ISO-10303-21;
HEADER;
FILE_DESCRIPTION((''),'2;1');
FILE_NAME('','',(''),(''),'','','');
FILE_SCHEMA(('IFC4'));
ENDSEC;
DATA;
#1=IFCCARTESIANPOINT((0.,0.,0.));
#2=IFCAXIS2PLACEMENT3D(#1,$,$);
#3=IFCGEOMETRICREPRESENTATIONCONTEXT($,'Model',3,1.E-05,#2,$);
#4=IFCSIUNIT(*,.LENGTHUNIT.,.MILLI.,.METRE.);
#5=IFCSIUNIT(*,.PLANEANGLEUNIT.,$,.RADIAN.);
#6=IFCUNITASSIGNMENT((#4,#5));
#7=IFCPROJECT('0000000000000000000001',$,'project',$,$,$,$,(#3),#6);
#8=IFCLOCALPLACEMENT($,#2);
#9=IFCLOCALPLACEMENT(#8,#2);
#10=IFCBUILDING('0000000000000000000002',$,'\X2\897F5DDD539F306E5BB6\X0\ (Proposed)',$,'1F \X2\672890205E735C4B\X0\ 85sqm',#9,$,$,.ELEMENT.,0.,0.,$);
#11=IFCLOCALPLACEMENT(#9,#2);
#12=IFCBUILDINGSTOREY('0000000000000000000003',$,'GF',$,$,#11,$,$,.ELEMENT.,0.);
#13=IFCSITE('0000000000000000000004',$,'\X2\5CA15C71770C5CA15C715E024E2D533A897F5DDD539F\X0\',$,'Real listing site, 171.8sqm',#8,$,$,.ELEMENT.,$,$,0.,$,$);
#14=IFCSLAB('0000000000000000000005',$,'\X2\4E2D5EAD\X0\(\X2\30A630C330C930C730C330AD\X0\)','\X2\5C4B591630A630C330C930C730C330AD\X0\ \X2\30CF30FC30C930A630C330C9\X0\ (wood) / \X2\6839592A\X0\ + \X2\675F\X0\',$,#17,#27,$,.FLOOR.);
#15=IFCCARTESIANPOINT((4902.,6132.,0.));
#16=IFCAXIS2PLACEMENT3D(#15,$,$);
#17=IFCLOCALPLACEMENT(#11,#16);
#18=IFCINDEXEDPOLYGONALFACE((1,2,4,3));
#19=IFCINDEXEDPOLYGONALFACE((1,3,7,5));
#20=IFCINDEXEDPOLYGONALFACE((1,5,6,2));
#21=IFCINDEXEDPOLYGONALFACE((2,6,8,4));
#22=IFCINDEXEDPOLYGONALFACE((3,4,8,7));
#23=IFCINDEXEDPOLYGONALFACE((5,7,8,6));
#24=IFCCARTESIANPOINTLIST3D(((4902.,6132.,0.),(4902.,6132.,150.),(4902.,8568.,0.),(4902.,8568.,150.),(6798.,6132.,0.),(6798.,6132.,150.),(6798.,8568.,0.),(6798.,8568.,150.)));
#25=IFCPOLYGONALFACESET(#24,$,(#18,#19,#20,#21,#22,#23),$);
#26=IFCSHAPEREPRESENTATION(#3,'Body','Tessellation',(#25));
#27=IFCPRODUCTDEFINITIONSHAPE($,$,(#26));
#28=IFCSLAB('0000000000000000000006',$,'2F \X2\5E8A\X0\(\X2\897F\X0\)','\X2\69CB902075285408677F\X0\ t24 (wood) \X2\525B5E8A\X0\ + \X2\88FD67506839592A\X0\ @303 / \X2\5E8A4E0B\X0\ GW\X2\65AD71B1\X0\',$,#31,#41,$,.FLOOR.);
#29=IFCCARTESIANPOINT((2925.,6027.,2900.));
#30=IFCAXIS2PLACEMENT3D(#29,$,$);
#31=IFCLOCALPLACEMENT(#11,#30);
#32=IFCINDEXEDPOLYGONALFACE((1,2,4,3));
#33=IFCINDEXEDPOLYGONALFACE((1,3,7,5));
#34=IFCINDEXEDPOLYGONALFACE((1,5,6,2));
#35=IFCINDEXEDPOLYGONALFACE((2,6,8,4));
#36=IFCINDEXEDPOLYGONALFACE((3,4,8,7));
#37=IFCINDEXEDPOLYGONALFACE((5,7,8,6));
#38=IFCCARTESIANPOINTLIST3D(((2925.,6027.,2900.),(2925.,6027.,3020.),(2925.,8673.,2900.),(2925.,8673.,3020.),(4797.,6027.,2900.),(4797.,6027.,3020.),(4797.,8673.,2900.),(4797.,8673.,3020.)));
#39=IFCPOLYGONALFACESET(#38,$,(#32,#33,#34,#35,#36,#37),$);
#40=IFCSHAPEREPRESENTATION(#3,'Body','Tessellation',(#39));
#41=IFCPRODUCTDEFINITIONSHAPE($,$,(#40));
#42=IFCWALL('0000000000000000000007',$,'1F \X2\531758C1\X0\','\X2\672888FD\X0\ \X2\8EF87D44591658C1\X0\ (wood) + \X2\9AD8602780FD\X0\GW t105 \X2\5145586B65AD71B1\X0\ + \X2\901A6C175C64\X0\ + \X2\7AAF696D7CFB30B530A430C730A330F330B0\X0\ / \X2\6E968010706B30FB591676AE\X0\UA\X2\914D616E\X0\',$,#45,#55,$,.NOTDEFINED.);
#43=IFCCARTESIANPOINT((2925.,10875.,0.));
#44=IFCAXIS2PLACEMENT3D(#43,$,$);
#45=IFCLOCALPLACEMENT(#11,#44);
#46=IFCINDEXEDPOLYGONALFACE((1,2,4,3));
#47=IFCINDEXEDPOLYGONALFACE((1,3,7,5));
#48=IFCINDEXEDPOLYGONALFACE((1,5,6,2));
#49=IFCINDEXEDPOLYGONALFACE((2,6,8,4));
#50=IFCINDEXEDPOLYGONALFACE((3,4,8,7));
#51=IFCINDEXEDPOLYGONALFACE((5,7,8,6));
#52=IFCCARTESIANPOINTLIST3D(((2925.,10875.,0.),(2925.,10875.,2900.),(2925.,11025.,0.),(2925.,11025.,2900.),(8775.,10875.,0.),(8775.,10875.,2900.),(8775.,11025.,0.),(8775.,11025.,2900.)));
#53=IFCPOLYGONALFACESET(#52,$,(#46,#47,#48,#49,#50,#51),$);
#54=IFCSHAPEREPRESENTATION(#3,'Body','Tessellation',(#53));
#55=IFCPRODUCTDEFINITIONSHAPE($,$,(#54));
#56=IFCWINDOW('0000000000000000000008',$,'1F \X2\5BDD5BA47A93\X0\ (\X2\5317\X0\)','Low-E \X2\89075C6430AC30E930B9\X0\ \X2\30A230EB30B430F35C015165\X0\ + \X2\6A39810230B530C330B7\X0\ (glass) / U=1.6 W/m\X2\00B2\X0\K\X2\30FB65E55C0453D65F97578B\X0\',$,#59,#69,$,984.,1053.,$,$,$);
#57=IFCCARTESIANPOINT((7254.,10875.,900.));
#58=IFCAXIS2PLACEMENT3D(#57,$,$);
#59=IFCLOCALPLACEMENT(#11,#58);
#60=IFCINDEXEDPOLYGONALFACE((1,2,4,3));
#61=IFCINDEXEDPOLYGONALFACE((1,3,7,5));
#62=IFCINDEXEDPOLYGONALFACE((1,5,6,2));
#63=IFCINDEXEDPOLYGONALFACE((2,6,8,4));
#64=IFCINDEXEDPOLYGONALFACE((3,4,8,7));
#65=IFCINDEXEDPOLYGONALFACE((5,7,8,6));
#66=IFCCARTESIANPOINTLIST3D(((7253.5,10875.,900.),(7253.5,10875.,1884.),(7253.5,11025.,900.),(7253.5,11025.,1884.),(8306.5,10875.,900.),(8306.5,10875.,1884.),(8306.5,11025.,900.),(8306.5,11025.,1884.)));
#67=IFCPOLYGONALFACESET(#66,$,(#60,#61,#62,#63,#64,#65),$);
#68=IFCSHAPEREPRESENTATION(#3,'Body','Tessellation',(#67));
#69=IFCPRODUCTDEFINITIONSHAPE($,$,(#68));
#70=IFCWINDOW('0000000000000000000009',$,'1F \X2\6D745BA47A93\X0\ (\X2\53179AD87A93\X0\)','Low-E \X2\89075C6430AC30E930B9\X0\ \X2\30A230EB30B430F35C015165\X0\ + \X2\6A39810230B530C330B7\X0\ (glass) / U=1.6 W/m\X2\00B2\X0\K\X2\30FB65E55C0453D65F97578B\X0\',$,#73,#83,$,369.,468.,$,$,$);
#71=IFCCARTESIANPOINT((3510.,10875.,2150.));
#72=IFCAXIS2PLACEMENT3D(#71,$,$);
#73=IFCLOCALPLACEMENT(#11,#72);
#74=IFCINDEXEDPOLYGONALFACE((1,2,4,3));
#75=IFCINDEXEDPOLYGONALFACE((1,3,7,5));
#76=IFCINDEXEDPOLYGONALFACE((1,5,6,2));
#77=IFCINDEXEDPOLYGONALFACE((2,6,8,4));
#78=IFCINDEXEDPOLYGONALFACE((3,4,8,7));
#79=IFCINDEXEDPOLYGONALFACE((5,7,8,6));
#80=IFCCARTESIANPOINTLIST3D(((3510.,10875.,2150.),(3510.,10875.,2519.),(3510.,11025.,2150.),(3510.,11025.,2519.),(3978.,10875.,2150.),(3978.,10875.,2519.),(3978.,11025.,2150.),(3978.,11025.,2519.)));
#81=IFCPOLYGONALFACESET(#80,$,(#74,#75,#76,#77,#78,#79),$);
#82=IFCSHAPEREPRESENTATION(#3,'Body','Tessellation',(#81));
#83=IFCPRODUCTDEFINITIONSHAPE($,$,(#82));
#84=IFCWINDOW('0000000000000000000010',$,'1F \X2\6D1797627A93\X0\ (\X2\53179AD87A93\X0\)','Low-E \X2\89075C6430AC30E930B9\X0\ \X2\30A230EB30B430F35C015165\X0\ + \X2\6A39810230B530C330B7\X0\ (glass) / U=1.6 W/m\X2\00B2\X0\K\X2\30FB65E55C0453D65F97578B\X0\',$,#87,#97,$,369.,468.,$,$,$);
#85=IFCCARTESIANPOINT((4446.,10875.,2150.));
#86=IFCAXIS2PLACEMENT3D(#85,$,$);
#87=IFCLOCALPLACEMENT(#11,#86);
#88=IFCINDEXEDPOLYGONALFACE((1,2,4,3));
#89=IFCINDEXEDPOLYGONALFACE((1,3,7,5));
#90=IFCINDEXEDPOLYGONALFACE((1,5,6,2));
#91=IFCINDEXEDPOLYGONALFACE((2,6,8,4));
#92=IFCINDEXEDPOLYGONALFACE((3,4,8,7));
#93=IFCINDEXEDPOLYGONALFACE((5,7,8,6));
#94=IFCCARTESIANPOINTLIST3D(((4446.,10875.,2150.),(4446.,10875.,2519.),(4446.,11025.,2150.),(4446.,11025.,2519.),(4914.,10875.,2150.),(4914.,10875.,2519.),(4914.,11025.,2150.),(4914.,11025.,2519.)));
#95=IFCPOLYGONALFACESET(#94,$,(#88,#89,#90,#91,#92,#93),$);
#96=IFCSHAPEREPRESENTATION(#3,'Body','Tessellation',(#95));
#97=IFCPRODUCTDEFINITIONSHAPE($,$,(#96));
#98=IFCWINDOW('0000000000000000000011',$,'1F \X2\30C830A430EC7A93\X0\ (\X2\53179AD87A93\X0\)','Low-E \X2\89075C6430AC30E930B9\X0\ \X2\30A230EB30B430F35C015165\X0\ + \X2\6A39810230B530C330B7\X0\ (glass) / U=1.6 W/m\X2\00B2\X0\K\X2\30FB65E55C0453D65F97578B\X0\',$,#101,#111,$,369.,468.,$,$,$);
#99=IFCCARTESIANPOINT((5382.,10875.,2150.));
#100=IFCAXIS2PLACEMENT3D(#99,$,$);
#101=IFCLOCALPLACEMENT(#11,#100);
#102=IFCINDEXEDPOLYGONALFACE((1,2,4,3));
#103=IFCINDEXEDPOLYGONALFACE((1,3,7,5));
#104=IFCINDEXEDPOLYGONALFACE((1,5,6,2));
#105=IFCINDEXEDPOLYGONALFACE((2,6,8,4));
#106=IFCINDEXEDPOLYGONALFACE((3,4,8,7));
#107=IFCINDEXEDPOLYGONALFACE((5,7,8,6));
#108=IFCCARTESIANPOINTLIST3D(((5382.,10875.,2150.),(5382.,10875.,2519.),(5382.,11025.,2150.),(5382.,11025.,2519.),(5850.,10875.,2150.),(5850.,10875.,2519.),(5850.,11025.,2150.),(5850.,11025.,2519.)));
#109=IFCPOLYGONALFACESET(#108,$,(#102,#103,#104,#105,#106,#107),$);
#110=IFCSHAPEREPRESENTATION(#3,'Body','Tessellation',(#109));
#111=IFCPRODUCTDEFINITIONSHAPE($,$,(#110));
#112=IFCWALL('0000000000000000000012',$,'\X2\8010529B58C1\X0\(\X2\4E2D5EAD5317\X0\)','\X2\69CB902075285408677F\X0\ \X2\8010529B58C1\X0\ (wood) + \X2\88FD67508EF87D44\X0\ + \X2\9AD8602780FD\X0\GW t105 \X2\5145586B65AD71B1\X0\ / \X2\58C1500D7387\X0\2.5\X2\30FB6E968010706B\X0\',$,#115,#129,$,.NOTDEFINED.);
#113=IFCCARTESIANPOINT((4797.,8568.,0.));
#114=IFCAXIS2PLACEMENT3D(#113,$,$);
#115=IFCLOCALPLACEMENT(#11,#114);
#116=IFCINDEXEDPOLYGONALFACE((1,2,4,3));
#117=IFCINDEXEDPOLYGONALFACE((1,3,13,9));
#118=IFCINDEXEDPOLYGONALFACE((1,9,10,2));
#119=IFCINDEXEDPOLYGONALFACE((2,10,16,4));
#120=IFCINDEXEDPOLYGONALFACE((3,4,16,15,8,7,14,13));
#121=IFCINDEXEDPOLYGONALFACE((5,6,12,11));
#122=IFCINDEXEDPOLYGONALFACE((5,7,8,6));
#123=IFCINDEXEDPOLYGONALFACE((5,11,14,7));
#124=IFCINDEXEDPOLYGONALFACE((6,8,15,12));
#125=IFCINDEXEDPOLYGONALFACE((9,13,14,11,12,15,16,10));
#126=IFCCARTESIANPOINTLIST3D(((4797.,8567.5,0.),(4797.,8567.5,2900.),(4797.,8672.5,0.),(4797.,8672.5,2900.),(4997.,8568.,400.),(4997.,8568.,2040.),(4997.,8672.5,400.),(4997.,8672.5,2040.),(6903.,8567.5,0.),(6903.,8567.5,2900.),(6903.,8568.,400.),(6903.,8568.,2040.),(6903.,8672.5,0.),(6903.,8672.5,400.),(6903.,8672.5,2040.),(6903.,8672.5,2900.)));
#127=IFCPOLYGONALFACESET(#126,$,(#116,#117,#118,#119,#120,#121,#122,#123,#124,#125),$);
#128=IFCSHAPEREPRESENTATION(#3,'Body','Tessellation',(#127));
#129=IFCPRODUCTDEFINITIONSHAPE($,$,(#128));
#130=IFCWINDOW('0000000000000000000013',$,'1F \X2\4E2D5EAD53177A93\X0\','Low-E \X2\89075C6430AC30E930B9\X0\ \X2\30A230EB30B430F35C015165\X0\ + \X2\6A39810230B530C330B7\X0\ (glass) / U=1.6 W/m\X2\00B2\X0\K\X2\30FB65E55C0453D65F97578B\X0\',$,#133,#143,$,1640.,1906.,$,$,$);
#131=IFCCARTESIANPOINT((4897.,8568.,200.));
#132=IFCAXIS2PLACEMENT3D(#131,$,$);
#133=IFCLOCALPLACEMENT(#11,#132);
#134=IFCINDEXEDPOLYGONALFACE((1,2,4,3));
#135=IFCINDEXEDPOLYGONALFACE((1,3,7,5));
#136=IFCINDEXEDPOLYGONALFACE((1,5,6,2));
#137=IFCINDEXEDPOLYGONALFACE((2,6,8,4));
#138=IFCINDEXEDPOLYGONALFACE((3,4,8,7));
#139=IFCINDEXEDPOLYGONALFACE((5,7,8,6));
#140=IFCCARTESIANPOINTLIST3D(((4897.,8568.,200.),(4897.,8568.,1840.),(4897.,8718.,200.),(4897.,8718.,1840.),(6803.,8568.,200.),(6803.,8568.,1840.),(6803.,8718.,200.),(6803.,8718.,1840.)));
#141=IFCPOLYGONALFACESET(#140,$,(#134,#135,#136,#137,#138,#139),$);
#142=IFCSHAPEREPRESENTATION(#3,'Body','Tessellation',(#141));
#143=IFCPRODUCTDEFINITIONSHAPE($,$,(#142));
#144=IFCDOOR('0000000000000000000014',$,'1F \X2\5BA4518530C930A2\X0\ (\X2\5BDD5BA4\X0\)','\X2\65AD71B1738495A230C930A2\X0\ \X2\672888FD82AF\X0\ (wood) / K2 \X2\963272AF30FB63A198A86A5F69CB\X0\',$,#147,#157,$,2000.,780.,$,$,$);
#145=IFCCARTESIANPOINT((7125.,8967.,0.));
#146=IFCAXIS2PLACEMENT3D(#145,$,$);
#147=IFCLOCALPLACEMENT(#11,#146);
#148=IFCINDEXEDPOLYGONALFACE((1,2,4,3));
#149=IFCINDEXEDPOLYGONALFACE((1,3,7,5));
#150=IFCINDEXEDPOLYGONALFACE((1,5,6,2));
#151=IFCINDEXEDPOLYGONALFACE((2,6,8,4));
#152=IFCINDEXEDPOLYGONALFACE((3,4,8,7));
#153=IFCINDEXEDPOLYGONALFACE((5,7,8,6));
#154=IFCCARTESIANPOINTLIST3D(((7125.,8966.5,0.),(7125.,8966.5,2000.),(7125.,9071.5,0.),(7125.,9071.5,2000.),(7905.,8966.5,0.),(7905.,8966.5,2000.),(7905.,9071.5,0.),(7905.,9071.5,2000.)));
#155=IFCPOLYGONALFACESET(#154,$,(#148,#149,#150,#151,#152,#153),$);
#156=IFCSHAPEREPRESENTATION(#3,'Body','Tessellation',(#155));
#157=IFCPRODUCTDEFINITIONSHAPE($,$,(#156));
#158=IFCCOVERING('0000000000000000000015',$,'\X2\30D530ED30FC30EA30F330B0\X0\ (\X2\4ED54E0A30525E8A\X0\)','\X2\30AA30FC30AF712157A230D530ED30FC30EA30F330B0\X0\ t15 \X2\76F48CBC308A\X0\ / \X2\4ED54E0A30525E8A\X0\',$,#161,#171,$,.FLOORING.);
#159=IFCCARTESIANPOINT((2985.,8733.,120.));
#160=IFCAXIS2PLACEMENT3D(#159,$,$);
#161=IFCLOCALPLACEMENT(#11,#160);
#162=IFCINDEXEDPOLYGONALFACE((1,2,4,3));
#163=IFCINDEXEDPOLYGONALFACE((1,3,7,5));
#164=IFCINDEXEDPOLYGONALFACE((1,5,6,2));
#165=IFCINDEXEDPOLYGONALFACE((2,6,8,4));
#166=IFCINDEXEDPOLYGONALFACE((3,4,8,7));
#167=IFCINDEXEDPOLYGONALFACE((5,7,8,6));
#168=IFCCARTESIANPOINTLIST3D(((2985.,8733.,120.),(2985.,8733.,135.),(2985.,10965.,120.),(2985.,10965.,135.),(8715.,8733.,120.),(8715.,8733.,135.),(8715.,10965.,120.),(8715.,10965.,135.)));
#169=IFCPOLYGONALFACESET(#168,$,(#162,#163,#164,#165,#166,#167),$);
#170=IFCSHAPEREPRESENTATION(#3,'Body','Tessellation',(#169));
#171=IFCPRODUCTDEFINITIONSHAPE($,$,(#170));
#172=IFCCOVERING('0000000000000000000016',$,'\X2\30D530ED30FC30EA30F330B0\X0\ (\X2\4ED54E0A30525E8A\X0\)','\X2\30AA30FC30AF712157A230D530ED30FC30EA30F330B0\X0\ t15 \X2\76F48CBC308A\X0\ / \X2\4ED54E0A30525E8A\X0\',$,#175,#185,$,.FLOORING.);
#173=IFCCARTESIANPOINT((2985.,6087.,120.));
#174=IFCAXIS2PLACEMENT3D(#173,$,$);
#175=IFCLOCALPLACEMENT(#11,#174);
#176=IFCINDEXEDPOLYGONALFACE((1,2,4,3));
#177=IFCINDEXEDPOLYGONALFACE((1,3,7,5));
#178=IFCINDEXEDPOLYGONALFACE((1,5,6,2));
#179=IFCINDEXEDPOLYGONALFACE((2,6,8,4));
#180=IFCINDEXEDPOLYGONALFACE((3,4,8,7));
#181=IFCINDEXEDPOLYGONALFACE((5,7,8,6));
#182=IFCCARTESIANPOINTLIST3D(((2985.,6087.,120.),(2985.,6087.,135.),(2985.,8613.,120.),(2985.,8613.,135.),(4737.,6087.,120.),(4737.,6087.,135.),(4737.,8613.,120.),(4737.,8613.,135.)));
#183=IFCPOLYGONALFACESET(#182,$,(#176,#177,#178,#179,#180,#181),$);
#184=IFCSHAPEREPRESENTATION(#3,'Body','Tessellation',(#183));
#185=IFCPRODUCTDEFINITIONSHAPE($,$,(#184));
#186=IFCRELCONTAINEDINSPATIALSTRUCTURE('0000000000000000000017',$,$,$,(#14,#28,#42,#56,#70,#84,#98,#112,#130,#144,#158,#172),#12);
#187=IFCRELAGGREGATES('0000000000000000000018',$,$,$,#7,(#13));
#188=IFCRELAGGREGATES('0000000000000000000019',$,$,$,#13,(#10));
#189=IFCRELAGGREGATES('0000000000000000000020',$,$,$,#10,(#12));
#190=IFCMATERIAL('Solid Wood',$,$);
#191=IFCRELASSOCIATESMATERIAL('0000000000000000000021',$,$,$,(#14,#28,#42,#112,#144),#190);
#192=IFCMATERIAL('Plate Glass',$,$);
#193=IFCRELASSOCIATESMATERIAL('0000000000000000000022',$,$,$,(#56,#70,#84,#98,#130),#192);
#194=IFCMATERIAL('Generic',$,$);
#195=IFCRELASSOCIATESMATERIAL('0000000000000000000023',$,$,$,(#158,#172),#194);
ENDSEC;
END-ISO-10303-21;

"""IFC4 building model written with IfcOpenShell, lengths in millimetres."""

from ifc_helpers import new_model, si_unit, frame, frame_2d, origin, place, context, project, spatial, rectangle, extrude, material, element, fill, save


model = new_model("IFC4")

# Units and contexts
model_context = context("Model", 3, precision=1e-05, world=origin())
ifc_project = project(units=[si_unit("LENGTHUNIT", "METRE", prefix="MILLI"), si_unit("PLANEANGLEUNIT", "RADIAN")], contexts=[model_context])

# Site, building, storey
site_placement = place(None, origin())
site = spatial("IfcSite", under=ifc_project, at=site_placement, Name="岡山県岡山市中区西川原", ObjectType="Real listing site, 171.8sqm", CompositionType="ELEMENT", RefElevation=0.0)
building_placement = place(site_placement, origin())
building = spatial("IfcBuilding", under=site, at=building_placement, Name="西川原の家 (Proposed)", ObjectType="1F 木造平屋 85sqm", CompositionType="ELEMENT", ElevationOfRefHeight=0.0, ElevationOfTerrain=0.0)
storey_placement = place(building_placement, origin())
storey = spatial("IfcBuildingStorey", under=building, at=storey_placement, Name="GF", CompositionType="ELEMENT", Elevation=0.0)

# Slabs
ifc_material_1 = material(Name="Solid Wood")
slab_1_placement = place(storey_placement, frame((4902.0, 6132.0, 0.0)))
element("IfcSlab", 1, at=slab_1_placement, inside=storey, material=ifc_material_1, Name="中庭(ウッドデッキ)", Description="屋外ウッドデッキ ハードウッド (wood) / 根太 + 束", PredefinedType="FLOOR", context=model_context, shape_type="SweptSolid", body=[
    extrude(rectangle(XDim=1896.0, YDim=2436.0, at=frame_2d((948.0, 1218.0))), frame((4902.0, 6132.0, 0.0)), (0.0, 0.0, 1.0), 150.0),
])
slab_2_placement = place(storey_placement, frame((2925.0, 6027.0, 2900.0)))
element("IfcSlab", 2, at=slab_2_placement, inside=storey, material=ifc_material_1, Name="2F 床(西)", Description="構造用合板 t24 (wood) 剛床 + 製材根太 @303 / 床下 GW断熱", PredefinedType="FLOOR", context=model_context, shape_type="SweptSolid", body=[
    extrude(rectangle(XDim=1872.0, YDim=2646.0, at=frame_2d((936.0, 1323.0))), frame((2925.0, 6027.0, 2900.0)), (0.0, 0.0, 1.0), 120.0),
])

# Wall, openings, windows
wall_1_placement = place(storey_placement, frame((2925.0, 10875.0, 0.0)))
wall_1 = element("IfcWall", 3, at=wall_1_placement, inside=storey, material=ifc_material_1, Name="1F 北壁", Description="木製 軸組外壁 (wood) + 高性能GW t105 充填断熱 + 通気層 + 窯業系サイディング / 準耐火・外皮UA配慮", PredefinedType="NOTDEFINED", context=model_context, shape_type="SweptSolid", body=[
    extrude(rectangle(XDim=5850.0, YDim=150.0, at=frame_2d((2925.0, 75.0))), frame((2925.0, 10875.0, 0.0)), (0.0, 0.0, 1.0), 2900.0),
])
opening_1_placement = place(storey_placement, frame((7254.0, 10875.0, 900.0)))
opening_1 = element("IfcOpeningElement", 4, at=opening_1_placement, cuts=wall_1, PredefinedType="NOTDEFINED", context=model_context, shape_type="SweptSolid", body=[
    extrude(rectangle(XDim=1053.0, YDim=150.0, at=frame_2d((526.0, 75.0))), frame((7254.0, 10875.0, 900.0)), (0.0, 0.0, 1.0), 984.0),
])
opening_2_placement = place(storey_placement, frame((3510.0, 10875.0, 2150.0)))
opening_2 = element("IfcOpeningElement", 5, at=opening_2_placement, cuts=wall_1, PredefinedType="NOTDEFINED", context=model_context, shape_type="SweptSolid", body=[
    extrude(rectangle(XDim=468.0, YDim=150.0, at=frame_2d((234.0, 75.0))), frame((3510.0, 10875.0, 2150.0)), (0.0, 0.0, 1.0), 369.0),
])
opening_3_placement = place(storey_placement, frame((4446.0, 10875.0, 2150.0)))
opening_3 = element("IfcOpeningElement", 6, at=opening_3_placement, cuts=wall_1, PredefinedType="NOTDEFINED", context=model_context, shape_type="SweptSolid", body=[
    extrude(rectangle(XDim=468.0, YDim=150.0, at=frame_2d((234.0, 75.0))), frame((4446.0, 10875.0, 2150.0)), (0.0, 0.0, 1.0), 369.0),
])
opening_4_placement = place(storey_placement, frame((5382.0, 10875.0, 2150.0)))
opening_4 = element("IfcOpeningElement", 7, at=opening_4_placement, cuts=wall_1, PredefinedType="NOTDEFINED", context=model_context, shape_type="SweptSolid", body=[
    extrude(rectangle(XDim=468.0, YDim=150.0, at=frame_2d((234.0, 75.0))), frame((5382.0, 10875.0, 2150.0)), (0.0, 0.0, 1.0), 369.0),
])
ifc_material_2 = material(Name="Plate Glass")
window_1_placement = place(storey_placement, frame((7254.0, 10875.0, 900.0)))
window_1 = element("IfcWindow", 8, at=window_1_placement, inside=storey, material=ifc_material_2, Name="1F 寝室窓 (北)", Description="Low-E 複層ガラス アルゴン封入 + 樹脂サッシ (glass) / U=1.6 W/m²K・日射取得型", OverallHeight=984.0, OverallWidth=1053.0, context=model_context, shape_type="SweptSolid", body=[
    extrude(rectangle(XDim=1053.0, YDim=150.0, at=frame_2d((526.0, 75.0))), frame((7254.0, 10875.0, 900.0)), (0.0, 0.0, 1.0), 984.0),
])
fill(opening_1, window_1)
window_2_placement = place(storey_placement, frame((3510.0, 10875.0, 2150.0)))
window_2 = element("IfcWindow", 9, at=window_2_placement, inside=storey, material=ifc_material_2, Name="1F 浴室窓 (北高窓)", Description="Low-E 複層ガラス アルゴン封入 + 樹脂サッシ (glass) / U=1.6 W/m²K・日射取得型", OverallHeight=369.0, OverallWidth=468.0, context=model_context, shape_type="SweptSolid", body=[
    extrude(rectangle(XDim=468.0, YDim=150.0, at=frame_2d((234.0, 75.0))), frame((3510.0, 10875.0, 2150.0)), (0.0, 0.0, 1.0), 369.0),
])
fill(opening_2, window_2)
window_3_placement = place(storey_placement, frame((4446.0, 10875.0, 2150.0)))
window_3 = element("IfcWindow", 10, at=window_3_placement, inside=storey, material=ifc_material_2, Name="1F 洗面窓 (北高窓)", Description="Low-E 複層ガラス アルゴン封入 + 樹脂サッシ (glass) / U=1.6 W/m²K・日射取得型", OverallHeight=369.0, OverallWidth=468.0, context=model_context, shape_type="SweptSolid", body=[
    extrude(rectangle(XDim=468.0, YDim=150.0, at=frame_2d((234.0, 75.0))), frame((4446.0, 10875.0, 2150.0)), (0.0, 0.0, 1.0), 369.0),
])
fill(opening_3, window_3)
window_4_placement = place(storey_placement, frame((5382.0, 10875.0, 2150.0)))
window_4 = element("IfcWindow", 11, at=window_4_placement, inside=storey, material=ifc_material_2, Name="1F トイレ窓 (北高窓)", Description="Low-E 複層ガラス アルゴン封入 + 樹脂サッシ (glass) / U=1.6 W/m²K・日射取得型", OverallHeight=369.0, OverallWidth=468.0, context=model_context, shape_type="SweptSolid", body=[
    extrude(rectangle(XDim=468.0, YDim=150.0, at=frame_2d((234.0, 75.0))), frame((5382.0, 10875.0, 2150.0)), (0.0, 0.0, 1.0), 369.0),
])
fill(opening_4, window_4)

# Wall, opening, window
wall_2_placement = place(storey_placement, frame((4797.0, 8568.0, 0.0)))
wall_2 = element("IfcWall", 12, at=wall_2_placement, inside=storey, material=ifc_material_1, Name="耐力壁(中庭北)", Description="構造用合板 耐力壁 (wood) + 製材軸組 + 高性能GW t105 充填断熱 / 壁倍率2.5・準耐火", PredefinedType="NOTDEFINED", context=model_context, shape_type="SweptSolid", body=[
    extrude(rectangle(XDim=2106.0, YDim=105.0, at=frame_2d((1053.0, 52.0))), frame((4797.0, 8568.0, 0.0)), (0.0, 0.0, 1.0), 2900.0),
])
opening_5_placement = place(storey_placement, frame((4897.0, 8568.0, 200.0)))
opening_5 = element("IfcOpeningElement", 13, at=opening_5_placement, cuts=wall_2, PredefinedType="NOTDEFINED", context=model_context, shape_type="SweptSolid", body=[
    extrude(rectangle(XDim=1906.0, YDim=150.0, at=frame_2d((953.0, 75.0))), frame((4897.0, 8568.0, 200.0)), (0.0, 0.0, 1.0), 1640.0),
])
window_5_placement = place(storey_placement, frame((4897.0, 8568.0, 200.0)))
window_5 = element("IfcWindow", 14, at=window_5_placement, inside=storey, material=ifc_material_2, Name="1F 中庭北窓", Description="Low-E 複層ガラス アルゴン封入 + 樹脂サッシ (glass) / U=1.6 W/m²K・日射取得型", OverallHeight=1640.0, OverallWidth=1906.0, context=model_context, shape_type="SweptSolid", body=[
    extrude(rectangle(XDim=1906.0, YDim=150.0, at=frame_2d((953.0, 75.0))), frame((4897.0, 8568.0, 200.0)), (0.0, 0.0, 1.0), 1640.0),
])
fill(opening_5, window_5)

# Door
door_1_placement = place(storey_placement, frame((7125.0, 8967.0, 0.0)))
element("IfcDoor", 15, at=door_1_placement, inside=storey, material=ifc_material_1, Name="1F 室内ドア (寝室)", Description="断熱玄関ドア 木製芯 (wood) / K2 防犯・採風機構", OverallHeight=2000.0, OverallWidth=780.0, context=model_context, shape_type="SweptSolid", body=[
    extrude(rectangle(XDim=780.0, YDim=105.0, at=frame_2d((390.0, 52.0))), frame((7125.0, 8967.0, 0.0)), (0.0, 0.0, 1.0), 2000.0),
])

# Coverings
ifc_material_3 = material(Name="Generic")
covering_1_placement = place(storey_placement, frame((2985.0, 8733.0, 120.0)))
element("IfcCovering", 16, at=covering_1_placement, inside=storey, material=ifc_material_3, Name="フローリング (仕上げ床)", Description="オーク無垢フローリング t15 直貼り / 仕上げ床", PredefinedType="FLOORING", context=model_context, shape_type="SweptSolid", body=[
    extrude(rectangle(XDim=5730.0, YDim=2232.0, at=frame_2d((2865.0, 1116.0))), frame((2985.0, 8733.0, 120.0)), (0.0, 0.0, 1.0), 15.0),
])
covering_2_placement = place(storey_placement, frame((2985.0, 6087.0, 120.0)))
element("IfcCovering", 17, at=covering_2_placement, inside=storey, material=ifc_material_3, Name="フローリング (仕上げ床)", Description="オーク無垢フローリング t15 直貼り / 仕上げ床", PredefinedType="FLOORING", context=model_context, shape_type="SweptSolid", body=[
    extrude(rectangle(XDim=1752.0, YDim=2526.0, at=frame_2d((876.0, 1263.0))), frame((2985.0, 6087.0, 120.0)), (0.0, 0.0, 1.0), 15.0),
])

save(model, "model.ifc")
